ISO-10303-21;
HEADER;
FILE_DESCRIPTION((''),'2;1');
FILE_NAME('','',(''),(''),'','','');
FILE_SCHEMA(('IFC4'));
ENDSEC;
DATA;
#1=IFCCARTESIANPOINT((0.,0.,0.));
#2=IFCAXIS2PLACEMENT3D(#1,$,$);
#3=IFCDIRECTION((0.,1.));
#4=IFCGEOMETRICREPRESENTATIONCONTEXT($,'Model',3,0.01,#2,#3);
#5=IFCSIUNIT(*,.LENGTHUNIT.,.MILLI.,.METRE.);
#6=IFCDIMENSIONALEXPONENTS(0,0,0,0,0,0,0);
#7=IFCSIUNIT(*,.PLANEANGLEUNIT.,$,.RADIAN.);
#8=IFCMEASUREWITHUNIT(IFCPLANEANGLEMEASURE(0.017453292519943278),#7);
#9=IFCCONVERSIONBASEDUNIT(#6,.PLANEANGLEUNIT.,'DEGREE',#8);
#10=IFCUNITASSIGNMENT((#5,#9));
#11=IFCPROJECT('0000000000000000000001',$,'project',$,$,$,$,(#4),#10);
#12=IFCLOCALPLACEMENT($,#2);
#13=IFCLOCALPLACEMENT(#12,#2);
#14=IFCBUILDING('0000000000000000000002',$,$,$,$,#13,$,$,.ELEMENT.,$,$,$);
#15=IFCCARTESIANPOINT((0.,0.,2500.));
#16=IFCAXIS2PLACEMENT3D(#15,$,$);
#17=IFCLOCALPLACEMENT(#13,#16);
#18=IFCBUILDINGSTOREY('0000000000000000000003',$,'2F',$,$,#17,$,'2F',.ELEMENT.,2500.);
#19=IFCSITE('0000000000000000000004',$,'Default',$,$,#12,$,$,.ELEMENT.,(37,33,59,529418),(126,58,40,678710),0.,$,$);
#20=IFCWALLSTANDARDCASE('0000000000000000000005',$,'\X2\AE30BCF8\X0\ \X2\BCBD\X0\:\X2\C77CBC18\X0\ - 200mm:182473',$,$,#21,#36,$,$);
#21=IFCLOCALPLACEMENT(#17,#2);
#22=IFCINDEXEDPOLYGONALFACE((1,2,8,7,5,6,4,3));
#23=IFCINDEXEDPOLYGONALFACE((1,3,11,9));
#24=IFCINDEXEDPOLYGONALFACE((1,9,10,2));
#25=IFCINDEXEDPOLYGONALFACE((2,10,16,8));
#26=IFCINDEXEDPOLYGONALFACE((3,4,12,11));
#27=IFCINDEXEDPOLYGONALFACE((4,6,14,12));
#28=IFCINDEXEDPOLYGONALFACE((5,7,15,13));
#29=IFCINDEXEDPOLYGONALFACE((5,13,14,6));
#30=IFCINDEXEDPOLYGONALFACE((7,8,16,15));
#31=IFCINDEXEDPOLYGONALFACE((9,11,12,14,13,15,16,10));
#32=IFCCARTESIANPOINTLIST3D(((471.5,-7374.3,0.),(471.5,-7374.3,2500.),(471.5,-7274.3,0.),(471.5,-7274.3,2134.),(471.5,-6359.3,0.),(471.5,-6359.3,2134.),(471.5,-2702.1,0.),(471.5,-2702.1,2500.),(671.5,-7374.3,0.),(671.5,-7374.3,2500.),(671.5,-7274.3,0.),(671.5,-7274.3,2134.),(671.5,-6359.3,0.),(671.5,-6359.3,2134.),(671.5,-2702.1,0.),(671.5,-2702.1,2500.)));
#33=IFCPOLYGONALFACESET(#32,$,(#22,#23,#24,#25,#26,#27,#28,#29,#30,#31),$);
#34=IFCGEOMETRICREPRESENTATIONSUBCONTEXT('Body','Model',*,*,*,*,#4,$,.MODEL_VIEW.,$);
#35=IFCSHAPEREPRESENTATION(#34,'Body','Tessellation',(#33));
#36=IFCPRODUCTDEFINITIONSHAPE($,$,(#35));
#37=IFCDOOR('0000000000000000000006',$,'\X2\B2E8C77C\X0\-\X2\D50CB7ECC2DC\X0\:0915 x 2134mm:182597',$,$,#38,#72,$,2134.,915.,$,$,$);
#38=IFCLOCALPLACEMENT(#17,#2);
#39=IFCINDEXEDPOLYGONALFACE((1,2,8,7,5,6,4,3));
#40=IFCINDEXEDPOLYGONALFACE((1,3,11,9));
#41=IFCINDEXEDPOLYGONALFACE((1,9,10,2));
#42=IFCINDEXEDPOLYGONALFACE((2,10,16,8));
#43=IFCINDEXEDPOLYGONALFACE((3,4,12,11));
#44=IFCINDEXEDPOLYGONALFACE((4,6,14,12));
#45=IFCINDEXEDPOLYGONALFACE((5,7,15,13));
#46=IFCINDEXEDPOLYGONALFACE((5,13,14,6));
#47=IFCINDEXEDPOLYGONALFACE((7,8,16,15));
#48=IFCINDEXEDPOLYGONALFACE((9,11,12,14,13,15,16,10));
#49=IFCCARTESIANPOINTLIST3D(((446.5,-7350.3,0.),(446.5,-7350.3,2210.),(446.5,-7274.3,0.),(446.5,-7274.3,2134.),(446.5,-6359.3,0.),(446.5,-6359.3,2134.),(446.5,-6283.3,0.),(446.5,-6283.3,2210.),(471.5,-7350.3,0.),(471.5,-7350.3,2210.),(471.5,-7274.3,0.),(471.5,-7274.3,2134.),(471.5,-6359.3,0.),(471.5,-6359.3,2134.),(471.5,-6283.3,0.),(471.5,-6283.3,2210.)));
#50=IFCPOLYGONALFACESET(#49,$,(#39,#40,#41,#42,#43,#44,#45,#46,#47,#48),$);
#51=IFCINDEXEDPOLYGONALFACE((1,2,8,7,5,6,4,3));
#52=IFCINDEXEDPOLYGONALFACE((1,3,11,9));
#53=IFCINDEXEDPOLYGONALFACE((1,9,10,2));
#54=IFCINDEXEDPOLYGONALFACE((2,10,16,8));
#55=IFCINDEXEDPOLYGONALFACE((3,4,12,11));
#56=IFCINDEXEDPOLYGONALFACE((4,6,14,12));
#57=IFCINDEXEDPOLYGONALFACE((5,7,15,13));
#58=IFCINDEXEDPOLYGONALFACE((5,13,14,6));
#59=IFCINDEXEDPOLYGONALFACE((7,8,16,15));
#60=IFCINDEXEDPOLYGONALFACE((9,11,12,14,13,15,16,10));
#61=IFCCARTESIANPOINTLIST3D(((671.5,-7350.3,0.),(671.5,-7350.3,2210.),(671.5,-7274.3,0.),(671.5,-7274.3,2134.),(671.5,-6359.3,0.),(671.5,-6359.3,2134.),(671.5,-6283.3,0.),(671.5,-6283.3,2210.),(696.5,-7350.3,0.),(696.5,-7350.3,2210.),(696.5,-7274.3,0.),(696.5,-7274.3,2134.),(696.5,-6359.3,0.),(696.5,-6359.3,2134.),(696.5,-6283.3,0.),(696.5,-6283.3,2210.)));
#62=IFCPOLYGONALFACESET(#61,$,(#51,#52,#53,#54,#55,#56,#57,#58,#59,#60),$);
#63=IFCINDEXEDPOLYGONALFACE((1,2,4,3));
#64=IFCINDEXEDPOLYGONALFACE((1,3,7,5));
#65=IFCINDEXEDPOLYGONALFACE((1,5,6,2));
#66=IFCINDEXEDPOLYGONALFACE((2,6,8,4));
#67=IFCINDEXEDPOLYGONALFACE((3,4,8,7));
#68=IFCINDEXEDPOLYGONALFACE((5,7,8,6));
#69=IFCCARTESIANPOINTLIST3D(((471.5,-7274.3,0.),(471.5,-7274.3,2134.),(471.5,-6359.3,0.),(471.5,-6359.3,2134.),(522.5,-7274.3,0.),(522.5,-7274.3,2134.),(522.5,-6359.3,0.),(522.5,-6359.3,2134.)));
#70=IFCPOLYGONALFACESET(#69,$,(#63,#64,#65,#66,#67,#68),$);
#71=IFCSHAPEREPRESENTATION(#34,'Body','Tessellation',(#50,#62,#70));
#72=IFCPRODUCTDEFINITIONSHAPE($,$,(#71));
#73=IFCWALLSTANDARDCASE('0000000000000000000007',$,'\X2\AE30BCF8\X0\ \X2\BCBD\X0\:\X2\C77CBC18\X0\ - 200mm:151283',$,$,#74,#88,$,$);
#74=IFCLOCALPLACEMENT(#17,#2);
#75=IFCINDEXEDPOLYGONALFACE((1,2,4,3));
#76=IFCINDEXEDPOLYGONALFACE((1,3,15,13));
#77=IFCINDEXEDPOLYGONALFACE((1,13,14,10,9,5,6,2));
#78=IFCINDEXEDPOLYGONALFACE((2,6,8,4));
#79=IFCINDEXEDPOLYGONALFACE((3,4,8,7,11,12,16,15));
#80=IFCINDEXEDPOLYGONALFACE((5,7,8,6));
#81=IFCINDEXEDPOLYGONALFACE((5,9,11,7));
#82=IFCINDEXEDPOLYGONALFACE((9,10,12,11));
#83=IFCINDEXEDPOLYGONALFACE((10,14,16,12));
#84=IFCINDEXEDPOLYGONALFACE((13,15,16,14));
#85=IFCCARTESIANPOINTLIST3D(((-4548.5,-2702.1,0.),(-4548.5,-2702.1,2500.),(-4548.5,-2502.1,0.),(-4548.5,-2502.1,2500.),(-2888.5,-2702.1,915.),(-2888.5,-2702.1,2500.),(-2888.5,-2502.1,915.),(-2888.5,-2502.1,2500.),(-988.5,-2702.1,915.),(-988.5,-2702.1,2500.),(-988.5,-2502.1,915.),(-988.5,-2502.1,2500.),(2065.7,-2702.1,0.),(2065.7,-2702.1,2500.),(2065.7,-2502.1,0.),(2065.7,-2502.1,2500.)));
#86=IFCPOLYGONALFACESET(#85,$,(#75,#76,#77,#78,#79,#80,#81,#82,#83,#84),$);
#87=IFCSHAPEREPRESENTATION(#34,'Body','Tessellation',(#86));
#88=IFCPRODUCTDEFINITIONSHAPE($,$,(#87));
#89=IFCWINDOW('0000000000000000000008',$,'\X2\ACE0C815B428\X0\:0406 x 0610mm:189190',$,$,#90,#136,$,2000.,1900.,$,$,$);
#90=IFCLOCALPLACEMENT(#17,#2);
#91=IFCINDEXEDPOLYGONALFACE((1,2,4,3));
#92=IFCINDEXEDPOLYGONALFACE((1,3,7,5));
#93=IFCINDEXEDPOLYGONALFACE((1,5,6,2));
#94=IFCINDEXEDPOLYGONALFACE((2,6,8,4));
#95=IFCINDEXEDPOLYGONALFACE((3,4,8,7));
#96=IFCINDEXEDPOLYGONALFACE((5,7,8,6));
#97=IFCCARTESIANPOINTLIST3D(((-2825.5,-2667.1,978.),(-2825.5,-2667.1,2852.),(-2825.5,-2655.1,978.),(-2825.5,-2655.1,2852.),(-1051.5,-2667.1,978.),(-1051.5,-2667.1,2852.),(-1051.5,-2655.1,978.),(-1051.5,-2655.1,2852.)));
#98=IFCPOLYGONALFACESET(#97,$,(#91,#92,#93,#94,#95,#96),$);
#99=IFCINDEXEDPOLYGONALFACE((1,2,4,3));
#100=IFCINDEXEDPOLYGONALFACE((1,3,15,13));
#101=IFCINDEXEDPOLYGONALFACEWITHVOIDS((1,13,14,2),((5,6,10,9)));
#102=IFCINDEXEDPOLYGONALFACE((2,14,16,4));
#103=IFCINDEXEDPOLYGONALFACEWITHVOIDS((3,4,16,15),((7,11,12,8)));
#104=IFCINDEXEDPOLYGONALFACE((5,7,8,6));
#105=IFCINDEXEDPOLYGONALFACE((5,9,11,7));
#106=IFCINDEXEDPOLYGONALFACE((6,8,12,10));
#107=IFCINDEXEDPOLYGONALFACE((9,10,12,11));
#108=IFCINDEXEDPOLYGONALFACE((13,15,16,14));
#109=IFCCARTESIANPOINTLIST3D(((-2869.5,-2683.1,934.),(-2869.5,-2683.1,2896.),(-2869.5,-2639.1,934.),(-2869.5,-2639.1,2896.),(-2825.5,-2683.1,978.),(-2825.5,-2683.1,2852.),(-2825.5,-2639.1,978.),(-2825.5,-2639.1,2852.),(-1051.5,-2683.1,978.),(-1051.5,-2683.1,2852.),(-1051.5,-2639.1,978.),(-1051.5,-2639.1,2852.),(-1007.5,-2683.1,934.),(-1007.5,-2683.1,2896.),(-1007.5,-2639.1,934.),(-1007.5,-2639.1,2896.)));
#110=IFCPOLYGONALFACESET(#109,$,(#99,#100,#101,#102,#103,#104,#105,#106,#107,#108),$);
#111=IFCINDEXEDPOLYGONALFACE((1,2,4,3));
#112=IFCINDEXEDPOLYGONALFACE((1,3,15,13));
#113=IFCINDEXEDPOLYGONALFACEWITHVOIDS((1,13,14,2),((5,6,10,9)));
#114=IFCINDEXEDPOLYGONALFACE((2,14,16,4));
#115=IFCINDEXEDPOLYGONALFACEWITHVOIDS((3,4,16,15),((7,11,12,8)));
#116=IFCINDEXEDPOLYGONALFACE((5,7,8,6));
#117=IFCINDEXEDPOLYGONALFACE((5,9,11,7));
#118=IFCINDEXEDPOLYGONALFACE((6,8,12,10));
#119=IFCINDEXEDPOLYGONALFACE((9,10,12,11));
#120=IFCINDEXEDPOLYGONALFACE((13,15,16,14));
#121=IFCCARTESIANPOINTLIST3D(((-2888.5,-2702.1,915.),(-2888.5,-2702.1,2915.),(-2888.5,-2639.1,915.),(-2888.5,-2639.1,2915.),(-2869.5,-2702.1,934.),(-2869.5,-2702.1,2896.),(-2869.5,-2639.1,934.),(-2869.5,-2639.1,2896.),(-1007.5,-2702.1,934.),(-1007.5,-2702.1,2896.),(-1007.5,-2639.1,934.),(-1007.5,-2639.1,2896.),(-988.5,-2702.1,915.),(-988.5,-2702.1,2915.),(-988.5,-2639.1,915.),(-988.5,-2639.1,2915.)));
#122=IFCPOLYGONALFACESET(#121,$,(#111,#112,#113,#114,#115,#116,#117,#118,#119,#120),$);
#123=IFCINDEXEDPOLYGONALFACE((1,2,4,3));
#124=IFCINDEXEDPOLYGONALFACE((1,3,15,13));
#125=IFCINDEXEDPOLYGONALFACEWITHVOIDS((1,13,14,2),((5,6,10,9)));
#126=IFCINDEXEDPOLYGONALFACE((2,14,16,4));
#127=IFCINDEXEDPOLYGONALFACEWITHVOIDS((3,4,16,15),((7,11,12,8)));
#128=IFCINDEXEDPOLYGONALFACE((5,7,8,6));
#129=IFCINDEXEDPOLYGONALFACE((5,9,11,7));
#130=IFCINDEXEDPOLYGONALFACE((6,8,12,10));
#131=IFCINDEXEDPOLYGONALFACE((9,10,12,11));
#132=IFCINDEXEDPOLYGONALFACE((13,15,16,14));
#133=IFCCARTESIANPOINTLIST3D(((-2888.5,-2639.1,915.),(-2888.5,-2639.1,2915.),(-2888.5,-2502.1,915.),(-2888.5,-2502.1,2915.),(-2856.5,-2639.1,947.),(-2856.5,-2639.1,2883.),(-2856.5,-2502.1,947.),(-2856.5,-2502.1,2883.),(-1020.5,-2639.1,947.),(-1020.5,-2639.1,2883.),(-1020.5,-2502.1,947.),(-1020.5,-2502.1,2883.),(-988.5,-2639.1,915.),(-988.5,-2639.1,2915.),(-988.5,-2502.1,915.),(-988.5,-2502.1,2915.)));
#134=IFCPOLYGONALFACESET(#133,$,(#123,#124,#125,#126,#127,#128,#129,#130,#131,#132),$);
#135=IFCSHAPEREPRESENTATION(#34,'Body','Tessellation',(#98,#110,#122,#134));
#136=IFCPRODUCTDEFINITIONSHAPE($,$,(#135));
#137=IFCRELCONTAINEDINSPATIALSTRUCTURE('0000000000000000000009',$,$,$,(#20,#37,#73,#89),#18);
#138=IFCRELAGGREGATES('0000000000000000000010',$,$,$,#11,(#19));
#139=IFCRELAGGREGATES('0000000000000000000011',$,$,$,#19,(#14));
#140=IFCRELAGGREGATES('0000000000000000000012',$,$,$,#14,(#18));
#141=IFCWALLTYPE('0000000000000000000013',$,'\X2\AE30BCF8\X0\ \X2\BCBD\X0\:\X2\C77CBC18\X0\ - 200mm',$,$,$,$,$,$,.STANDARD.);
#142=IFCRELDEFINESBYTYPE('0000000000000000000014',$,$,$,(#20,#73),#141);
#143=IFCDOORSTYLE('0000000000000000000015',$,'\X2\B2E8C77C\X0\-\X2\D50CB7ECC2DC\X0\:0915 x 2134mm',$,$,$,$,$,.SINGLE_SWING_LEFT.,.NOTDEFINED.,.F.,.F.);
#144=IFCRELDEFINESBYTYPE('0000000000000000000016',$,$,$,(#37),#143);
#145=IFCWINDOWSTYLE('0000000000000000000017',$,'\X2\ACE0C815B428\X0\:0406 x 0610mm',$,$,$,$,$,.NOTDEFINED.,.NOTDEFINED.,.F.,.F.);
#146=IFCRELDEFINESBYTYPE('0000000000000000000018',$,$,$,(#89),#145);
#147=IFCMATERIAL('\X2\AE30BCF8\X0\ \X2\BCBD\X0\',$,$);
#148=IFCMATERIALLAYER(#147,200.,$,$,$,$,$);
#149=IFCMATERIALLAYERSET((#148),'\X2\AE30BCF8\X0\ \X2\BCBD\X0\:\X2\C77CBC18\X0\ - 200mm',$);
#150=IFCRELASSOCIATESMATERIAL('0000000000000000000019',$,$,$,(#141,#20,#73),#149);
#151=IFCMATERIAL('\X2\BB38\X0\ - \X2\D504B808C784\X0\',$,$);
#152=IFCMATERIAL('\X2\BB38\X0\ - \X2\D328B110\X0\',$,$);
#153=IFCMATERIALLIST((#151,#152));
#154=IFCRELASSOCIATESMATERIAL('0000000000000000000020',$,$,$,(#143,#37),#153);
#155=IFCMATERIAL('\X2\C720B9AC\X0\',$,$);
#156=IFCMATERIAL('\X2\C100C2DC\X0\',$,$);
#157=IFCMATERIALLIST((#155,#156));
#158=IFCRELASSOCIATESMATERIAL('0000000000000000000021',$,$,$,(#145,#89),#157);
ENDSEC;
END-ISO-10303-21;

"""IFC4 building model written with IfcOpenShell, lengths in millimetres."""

from ifc_helpers import new_model, entity, si_unit, converted_unit, direction, frame, frame_2d, origin, place, context, subcontext, project, spatial, polyline, rectangle, outline, extrude, source, transform, mapped, material, material_list, layer, layer_set, layer_usage, type_object, type_shapes, element, fill, save


model = new_model("IFC4")

# Units and contexts
model_context = context("Model", 3, precision=0.01, world=origin(), true_north=direction((0.0, 1.0)))
body_context = subcontext(model_context, "Body", "Model", "MODEL_VIEW")
ifc_project = project(units=[si_unit("LENGTHUNIT", "METRE", prefix="MILLI"), converted_unit("PLANEANGLEUNIT", "DEGREE", entity("IfcPlaneAngleMeasure", 0.017453292519943278), si_unit("PLANEANGLEUNIT", "RADIAN"), dimensions=[0, 0, 0, 0, 0, 0, 0])], contexts=[model_context])

# Site, building, storey
site_placement = place(None, origin())
site = spatial("IfcSite", under=ifc_project, at=site_placement, Name="Default", CompositionType="ELEMENT", RefLatitude=(37, 33, 59, 529418), RefLongitude=(126, 58, 40, 678710), RefElevation=0.0)
building_placement = place(site_placement, origin())
building = spatial("IfcBuilding", under=site, at=building_placement, CompositionType="ELEMENT")
storey_placement = place(building_placement, frame((0.0, 0.0, 2500.0)))
storey = spatial("IfcBuildingStorey", under=building, at=storey_placement, Name="2F", LongName="2F", CompositionType="ELEMENT", Elevation=2500.0)

# Shared definitions
ifc_material_1 = material(Name="기본 벽")
ifc_layer_1 = layer(ifc_material_1, 200.0)
ifc_layer_set_1 = layer_set([ifc_layer_1], Name="기본 벽:일반 - 200mm")
wall_type = type_object("IfcWallType", Name="기본 벽:일반 - 200mm", PredefinedType="STANDARD", material=ifc_layer_set_1)
ifc_material_2 = material(Name="문 - 프레임")
ifc_material_3 = material(Name="문 - 패널")
ifc_material_list_1 = material_list([ifc_material_2, ifc_material_3])
door_style = type_object("IfcDoorStyle", Name="단일-플러시:0915 x 2134mm", ConstructionType="NOTDEFINED", OperationType="SINGLE_SWING_LEFT", ParameterTakesPrecedence=False, Sizeable=False, material=ifc_material_list_1)
shared_shape_1 = source(origin(), body_context, "Body", "SweptSolid", [
    extrude(outline(polyline([(-533.5, -1124.0), (533.5, -1124.0), (533.5, 1086.0), (457.5, 1086.0), (457.5, -1048.0), (-457.5, -1048.0), (-457.5, 1086.0), (-533.5, 1086.0), (-533.5, -1124.0)])), frame((457.5, 225.0, 1086.0), z_axis=(0.0, -1.0, 0.0), x_axis=(-1.0, 0.0, 0.0)), (0.0, 0.0, 1.0), 25.0),
    extrude(outline(polyline([(-1124.0, -533.5), (1086.0, -533.5), (1086.0, -457.5), (-1048.0, -457.5), (-1048.0, 457.5), (1086.0, 457.5), (1086.0, 533.5), (-1124.0, 533.5), (-1124.0, -533.5)])), frame((457.5, 0.0, 1086.0), z_axis=(0.0, -1.0, 0.0), x_axis=(0.0, 0.0, -1.0)), (0.0, 0.0, 1.0), 25.0),
    extrude(rectangle(XDim=915.0, YDim=51.0, at=frame_2d((0.0, 0.0), x_axis=(1.0, 0.0))), frame((457.5, 174.5, 0.0)), (0.0, 0.0, 1.0), 2134.0),
])
type_shapes(door_style, [shared_shape_1])

# Shared definitions
ifc_material_4 = material(Name="유리")
ifc_material_5 = material(Name="섀시")
ifc_material_list_2 = material_list([ifc_material_4, ifc_material_5])
window_style = type_object("IfcWindowStyle", Name="고정됨:0406 x 0610mm", ConstructionType="NOTDEFINED", OperationType="NOTDEFINED", ParameterTakesPrecedence=False, Sizeable=False, material=ifc_material_list_2)
shared_shape_2 = source(origin(), body_context, "Body", "SweptSolid", [
    extrude(rectangle(XDim=12.0, YDim=1774.0, at=frame_2d((0.0, 0.0), x_axis=(1.0, 0.0))), frame((950.0, 159.0, 63.0), z_axis=(0.0, 0.0, 1.0), x_axis=(0.0, -1.0, 0.0)), (0.0, 0.0, 1.0), 1874.0),
    extrude(outline(polyline([(-931.0, -981.0), (931.0, -981.0), (931.0, 981.0), (-931.0, 981.0), (-931.0, -981.0)]), holes=[polyline([(-887.0, -937.0), (-887.0, 937.0), (887.0, 937.0), (887.0, -937.0), (-887.0, -937.0)])]), frame((950.0, 137.0, 1000.0), z_axis=(0.0, 1.0, 0.0), x_axis=(1.0, 0.0, 0.0)), (0.0, 0.0, 1.0), 44.0),
    extrude(outline(polyline([(-950.0, -1000.0), (950.0, -1000.0), (950.0, 1000.0), (-950.0, 1000.0), (-950.0, -1000.0)]), holes=[polyline([(-931.0, -981.0), (-931.0, 981.0), (931.0, 981.0), (931.0, -981.0), (-931.0, -981.0)])]), frame((950.0, 137.0, 1000.0), z_axis=(0.0, 1.0, 0.0), x_axis=(1.0, 0.0, 0.0)), (0.0, 0.0, 1.0), 63.0),
    extrude(outline(polyline([(-950.0, -1000.0), (950.0, -1000.0), (950.0, 1000.0), (-950.0, 1000.0), (-950.0, -1000.0)]), holes=[polyline([(-918.0, -968.0), (-918.0, 968.0), (918.0, 968.0), (918.0, -968.0), (-918.0, -968.0)])]), frame((950.0, 0.0, 1000.0), z_axis=(0.0, 1.0, 0.0), x_axis=(1.0, 0.0, 0.0)), (0.0, 0.0, 1.0), 137.0),
])
type_shapes(window_style, [shared_shape_2])

# Wall, opening, door
ifc_layer_usage_1 = layer_usage(ifc_layer_set_1, "AXIS2", "NEGATIVE", 100.0)
wall_1_placement = place(storey_placement, frame((571.5, -7374.3, 0.0), z_axis=(0.0, 0.0, 1.0), x_axis=(0.0, 1.0, 0.0)))
wall_1 = element("IfcWallStandardCase", 1, at=wall_1_placement, inside=storey, type_object=wall_type, material=ifc_layer_usage_1, Name="기본 벽:일반 - 200mm:182473", context=body_context, shape_type="SweptSolid", body=[
    extrude(rectangle(XDim=4672.2, YDim=200.0, at=frame_2d((2336.1, 0.0), x_axis=(1.0, 0.0))), origin(), (0.0, 0.0, 1.0), 2500.0),
])
opening_1_placement = place(wall_1_placement, frame((100.0, -100.0, 0.0)))
opening_1 = element("IfcOpeningElement", 2, at=opening_1_placement, cuts=wall_1, ObjectType="Opening", context=body_context, shape_type="SweptSolid", body=[
    extrude(rectangle(XDim=915.0, YDim=2134.0, at=frame_2d((1067.0, 457.5), x_axis=(0.0, -1.0))), frame((0.0, 0.0, 0.0), z_axis=(0.0, 1.0, 0.0), x_axis=(0.0, 0.0, 1.0)), (0.0, 0.0, 1.0), 200.0),
])
door_1_placement = place(opening_1_placement, origin())
door_1 = element("IfcDoor", 3, at=door_1_placement, inside=storey, type_object=door_style, material=ifc_material_list_1, Name="단일-플러시:0915 x 2134mm:182597", OverallHeight=2134.0, OverallWidth=915.0, context=body_context, shape_type="MappedRepresentation", body=[
    mapped(shared_shape_1, transform((0.0, 0.0, 0.0), scale=1.0)),
])
fill(opening_1, door_1)

# Wall, opening, window
ifc_layer_usage_2 = layer_usage(ifc_layer_set_1, "AXIS2", "NEGATIVE", 100.0)
wall_2_placement = place(storey_placement, frame((-4548.5, -2602.1, 0.0)))
wall_2 = element("IfcWallStandardCase", 4, at=wall_2_placement, inside=storey, type_object=wall_type, material=ifc_layer_usage_2, Name="기본 벽:일반 - 200mm:151283", context=body_context, shape_type="SweptSolid", body=[
    extrude(rectangle(XDim=6614.2, YDim=200.0, at=frame_2d((3307.1, 0.0), x_axis=(-1.0, 0.0))), origin(), (0.0, 0.0, 1.0), 2500.0),
])
opening_2_placement = place(wall_2_placement, frame((3560.0, 100.0, 915.0)))
opening_2 = element("IfcOpeningElement", 5, at=opening_2_placement, cuts=wall_2, ObjectType="Opening", context=body_context, shape_type="SweptSolid", body=[
    extrude(rectangle(XDim=2000.0, YDim=1900.0, at=frame_2d((1000.0, 950.0), x_axis=(1.0, 0.0))), frame((0.0, 0.0, 0.0), z_axis=(0.0, -1.0, 0.0), x_axis=(0.0, 0.0, 1.0)), (0.0, 0.0, 1.0), 200.0),
])
window_1_placement = place(opening_2_placement, frame((0.0, 0.0, 0.0), z_axis=(0.0, 0.0, 1.0), x_axis=(-1.0, 0.0, 0.0)))
window_1 = element("IfcWindow", 6, at=window_1_placement, inside=storey, type_object=window_style, material=ifc_material_list_2, Name="고정됨:0406 x 0610mm:189190", OverallHeight=2000.0, OverallWidth=1900.0, context=body_context, shape_type="MappedRepresentation", body=[
    mapped(shared_shape_2, transform((0.0, 0.0, 0.0), scale=1.0)),
])
fill(opening_2, window_1)

save(model, "model.ifc")
